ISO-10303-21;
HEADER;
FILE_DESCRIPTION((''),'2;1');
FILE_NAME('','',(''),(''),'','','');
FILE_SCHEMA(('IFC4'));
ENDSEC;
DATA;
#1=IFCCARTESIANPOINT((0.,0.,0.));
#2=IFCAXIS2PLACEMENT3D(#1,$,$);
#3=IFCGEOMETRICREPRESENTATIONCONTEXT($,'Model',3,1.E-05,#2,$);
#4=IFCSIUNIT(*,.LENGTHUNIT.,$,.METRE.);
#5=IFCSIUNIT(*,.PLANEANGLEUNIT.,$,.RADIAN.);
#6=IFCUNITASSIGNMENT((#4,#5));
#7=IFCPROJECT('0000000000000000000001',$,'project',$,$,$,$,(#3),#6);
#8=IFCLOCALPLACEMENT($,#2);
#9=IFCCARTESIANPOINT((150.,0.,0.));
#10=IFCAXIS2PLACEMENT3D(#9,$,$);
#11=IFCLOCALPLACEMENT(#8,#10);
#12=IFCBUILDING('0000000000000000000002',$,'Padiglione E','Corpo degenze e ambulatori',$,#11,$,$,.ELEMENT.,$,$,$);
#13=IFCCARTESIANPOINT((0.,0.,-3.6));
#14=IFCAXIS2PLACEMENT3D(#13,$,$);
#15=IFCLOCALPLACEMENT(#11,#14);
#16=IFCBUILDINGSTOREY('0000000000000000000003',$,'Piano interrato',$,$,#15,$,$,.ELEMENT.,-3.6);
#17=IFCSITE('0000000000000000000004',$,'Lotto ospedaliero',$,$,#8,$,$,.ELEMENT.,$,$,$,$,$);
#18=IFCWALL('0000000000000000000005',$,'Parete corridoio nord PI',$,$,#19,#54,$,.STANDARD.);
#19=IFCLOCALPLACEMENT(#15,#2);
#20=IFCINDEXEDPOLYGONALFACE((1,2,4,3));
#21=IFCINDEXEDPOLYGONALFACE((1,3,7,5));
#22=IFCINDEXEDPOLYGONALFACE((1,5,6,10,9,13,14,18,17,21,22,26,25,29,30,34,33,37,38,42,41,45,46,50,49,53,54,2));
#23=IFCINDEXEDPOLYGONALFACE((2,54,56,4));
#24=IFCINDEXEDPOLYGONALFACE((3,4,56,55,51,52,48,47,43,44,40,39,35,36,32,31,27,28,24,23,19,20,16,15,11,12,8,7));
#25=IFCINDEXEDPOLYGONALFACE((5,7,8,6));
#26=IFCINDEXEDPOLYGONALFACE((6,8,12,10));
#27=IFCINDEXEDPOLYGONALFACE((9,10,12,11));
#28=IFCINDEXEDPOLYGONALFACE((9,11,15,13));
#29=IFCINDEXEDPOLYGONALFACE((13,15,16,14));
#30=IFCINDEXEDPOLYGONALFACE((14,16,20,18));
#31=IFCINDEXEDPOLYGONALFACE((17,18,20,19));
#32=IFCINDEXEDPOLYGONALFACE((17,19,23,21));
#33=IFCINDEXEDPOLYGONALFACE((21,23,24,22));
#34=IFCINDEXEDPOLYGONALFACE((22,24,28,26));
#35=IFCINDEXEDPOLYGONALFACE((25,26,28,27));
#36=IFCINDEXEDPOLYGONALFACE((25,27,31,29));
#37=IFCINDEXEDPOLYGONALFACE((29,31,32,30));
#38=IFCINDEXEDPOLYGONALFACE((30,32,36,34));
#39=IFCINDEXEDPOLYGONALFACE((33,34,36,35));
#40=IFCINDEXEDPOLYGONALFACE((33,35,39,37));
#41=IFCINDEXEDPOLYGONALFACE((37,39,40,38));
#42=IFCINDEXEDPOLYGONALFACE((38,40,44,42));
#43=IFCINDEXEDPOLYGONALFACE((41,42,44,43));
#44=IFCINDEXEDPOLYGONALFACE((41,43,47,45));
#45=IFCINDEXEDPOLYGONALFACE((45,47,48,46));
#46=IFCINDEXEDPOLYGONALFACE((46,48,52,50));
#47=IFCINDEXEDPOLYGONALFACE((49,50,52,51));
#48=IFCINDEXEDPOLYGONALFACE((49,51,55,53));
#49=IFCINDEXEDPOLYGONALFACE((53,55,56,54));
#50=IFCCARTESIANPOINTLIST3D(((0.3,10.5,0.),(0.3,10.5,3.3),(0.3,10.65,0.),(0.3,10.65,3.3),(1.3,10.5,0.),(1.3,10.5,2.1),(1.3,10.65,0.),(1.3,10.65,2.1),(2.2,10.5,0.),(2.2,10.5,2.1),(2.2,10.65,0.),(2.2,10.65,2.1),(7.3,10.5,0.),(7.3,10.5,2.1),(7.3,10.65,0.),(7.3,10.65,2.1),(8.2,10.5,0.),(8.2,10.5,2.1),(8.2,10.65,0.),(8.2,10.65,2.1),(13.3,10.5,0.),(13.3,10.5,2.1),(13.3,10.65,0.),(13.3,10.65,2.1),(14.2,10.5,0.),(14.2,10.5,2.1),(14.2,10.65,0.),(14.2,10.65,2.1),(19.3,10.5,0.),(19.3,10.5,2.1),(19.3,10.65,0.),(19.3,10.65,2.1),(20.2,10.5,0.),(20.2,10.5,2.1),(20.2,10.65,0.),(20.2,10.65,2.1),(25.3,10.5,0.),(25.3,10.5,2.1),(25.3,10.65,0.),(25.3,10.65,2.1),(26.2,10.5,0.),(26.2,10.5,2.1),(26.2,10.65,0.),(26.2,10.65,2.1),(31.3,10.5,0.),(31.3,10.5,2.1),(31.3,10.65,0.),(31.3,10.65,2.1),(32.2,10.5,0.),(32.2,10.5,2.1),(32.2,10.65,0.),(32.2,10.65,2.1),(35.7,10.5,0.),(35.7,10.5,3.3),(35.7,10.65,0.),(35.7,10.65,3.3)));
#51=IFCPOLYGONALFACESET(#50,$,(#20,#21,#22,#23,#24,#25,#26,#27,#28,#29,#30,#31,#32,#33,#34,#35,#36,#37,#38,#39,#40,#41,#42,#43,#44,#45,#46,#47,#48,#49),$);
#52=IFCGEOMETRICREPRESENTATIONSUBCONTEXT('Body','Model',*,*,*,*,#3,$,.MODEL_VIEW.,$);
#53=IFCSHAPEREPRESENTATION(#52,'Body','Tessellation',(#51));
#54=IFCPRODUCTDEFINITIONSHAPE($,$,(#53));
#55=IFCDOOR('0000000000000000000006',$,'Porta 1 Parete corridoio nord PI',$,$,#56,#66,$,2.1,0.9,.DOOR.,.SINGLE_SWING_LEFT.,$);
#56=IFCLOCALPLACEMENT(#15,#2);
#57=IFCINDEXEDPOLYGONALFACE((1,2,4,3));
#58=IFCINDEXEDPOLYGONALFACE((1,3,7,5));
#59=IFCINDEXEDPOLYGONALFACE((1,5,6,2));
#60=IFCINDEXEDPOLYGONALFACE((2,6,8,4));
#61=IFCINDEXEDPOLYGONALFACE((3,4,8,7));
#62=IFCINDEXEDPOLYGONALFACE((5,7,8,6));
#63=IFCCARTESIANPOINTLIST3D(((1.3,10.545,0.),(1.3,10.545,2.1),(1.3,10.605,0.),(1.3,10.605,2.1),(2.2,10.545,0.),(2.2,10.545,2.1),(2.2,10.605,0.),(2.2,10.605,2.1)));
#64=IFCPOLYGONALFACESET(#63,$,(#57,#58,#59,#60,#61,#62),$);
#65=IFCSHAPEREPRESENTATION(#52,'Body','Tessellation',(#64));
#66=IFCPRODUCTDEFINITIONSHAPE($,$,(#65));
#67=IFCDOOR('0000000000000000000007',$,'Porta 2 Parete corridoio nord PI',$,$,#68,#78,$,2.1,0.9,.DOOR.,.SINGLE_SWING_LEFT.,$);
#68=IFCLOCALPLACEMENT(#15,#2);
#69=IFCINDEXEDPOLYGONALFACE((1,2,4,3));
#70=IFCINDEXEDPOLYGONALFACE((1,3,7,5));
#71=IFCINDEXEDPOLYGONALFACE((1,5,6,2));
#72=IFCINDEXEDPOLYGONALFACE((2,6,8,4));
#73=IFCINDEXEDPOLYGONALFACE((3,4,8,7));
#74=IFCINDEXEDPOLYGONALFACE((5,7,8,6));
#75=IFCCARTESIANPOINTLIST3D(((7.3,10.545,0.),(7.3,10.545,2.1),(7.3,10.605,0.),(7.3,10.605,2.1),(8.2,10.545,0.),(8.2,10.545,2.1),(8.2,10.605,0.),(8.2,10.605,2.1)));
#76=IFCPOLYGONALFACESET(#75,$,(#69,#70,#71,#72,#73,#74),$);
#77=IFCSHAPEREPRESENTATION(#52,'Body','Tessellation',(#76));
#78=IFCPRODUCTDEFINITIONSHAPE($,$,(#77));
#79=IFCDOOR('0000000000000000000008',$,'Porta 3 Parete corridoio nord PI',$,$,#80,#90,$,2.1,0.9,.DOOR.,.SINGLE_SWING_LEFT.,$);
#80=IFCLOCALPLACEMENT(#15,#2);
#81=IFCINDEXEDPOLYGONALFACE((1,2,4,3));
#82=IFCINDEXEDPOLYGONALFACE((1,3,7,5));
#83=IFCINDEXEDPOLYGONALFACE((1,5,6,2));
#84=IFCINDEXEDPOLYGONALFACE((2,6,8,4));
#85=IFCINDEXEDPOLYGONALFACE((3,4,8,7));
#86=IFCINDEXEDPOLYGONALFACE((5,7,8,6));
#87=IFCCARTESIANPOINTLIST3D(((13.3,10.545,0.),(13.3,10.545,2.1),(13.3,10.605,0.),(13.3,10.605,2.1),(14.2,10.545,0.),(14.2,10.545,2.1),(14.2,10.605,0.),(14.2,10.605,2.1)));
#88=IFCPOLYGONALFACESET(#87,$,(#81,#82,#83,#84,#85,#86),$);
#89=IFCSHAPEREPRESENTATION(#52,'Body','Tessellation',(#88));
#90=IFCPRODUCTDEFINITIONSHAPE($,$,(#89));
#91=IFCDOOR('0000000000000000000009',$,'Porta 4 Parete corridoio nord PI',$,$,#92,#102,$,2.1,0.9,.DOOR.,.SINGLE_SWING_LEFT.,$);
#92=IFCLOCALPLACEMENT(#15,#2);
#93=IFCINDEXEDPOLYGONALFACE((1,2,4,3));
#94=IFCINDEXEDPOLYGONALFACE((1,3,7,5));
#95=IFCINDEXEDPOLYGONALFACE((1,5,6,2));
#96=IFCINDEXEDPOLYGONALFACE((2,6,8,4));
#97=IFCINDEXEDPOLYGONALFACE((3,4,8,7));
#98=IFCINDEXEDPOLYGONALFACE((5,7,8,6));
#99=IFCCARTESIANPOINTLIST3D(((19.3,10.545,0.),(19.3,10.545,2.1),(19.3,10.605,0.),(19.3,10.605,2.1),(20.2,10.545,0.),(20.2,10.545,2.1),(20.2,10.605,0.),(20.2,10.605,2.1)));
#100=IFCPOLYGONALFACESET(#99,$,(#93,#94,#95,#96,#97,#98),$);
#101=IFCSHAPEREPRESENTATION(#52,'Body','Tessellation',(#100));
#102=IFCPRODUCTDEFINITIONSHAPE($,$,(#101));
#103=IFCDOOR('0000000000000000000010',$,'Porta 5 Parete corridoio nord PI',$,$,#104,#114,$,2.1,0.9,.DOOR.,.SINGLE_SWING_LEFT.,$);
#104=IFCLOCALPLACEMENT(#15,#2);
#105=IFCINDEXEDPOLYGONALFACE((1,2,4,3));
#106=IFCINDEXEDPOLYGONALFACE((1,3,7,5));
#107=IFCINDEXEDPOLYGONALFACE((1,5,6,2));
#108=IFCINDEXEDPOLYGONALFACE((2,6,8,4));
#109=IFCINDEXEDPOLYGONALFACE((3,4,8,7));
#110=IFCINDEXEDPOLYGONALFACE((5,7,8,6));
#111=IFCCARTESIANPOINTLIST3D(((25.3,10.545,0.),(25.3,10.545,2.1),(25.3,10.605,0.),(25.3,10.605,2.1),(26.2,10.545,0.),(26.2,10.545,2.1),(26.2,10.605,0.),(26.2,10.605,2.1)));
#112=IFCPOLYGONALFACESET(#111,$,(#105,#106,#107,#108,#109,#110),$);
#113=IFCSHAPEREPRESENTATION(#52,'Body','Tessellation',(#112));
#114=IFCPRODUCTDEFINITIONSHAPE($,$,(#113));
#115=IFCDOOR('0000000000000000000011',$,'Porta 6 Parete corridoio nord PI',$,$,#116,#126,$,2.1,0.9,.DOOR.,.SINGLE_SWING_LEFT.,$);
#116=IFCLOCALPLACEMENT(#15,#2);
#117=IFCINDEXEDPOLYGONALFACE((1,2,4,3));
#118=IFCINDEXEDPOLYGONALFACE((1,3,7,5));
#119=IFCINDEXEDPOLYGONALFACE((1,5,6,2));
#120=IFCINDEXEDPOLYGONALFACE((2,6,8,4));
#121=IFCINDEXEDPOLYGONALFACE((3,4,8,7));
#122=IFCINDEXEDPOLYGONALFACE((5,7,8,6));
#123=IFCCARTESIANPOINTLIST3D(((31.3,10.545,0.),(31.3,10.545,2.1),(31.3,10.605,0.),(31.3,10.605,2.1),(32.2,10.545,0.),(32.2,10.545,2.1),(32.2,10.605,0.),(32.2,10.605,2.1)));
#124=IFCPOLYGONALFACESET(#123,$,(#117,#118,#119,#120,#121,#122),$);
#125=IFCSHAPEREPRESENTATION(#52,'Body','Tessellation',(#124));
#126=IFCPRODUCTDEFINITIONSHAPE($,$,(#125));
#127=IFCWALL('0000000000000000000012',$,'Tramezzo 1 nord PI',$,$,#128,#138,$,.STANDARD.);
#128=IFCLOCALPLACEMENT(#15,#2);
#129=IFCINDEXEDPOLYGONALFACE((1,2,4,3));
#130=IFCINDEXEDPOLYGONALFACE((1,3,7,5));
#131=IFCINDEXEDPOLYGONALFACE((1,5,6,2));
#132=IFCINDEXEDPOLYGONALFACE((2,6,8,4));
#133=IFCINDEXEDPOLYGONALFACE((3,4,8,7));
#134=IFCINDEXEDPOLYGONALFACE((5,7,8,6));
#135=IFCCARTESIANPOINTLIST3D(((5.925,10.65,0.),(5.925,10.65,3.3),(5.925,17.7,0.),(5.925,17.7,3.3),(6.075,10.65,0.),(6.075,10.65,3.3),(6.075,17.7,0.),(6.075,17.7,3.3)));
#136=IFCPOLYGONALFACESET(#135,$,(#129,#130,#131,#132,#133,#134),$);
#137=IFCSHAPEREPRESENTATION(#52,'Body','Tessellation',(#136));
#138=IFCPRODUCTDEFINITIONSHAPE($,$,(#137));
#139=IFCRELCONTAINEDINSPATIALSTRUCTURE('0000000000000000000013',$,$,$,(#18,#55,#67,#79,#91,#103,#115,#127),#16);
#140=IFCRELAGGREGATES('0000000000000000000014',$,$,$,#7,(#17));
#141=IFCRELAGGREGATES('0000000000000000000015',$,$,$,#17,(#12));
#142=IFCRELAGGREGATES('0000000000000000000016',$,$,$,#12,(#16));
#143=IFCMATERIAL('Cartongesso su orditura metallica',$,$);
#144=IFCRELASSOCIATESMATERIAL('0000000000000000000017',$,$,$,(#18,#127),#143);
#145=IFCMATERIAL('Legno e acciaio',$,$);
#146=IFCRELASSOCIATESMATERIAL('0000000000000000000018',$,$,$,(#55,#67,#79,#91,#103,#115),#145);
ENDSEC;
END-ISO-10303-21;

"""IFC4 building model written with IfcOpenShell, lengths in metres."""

from ifc_helpers import new_model, si_unit, frame, frame_2d, origin, place, context, subcontext, project, spatial, rectangle, extrude, material, element, fill, save


model = new_model("IFC4")

# Units and contexts
model_context = context("Model", 3, precision=1e-05, world=origin())
body_context = subcontext(model_context, "Body", "Model", "MODEL_VIEW")
ifc_project = project(units=[si_unit("LENGTHUNIT", "METRE"), si_unit("PLANEANGLEUNIT", "RADIAN")], contexts=[model_context])

# Site, building, storey
site_placement = place(None, origin())
site = spatial("IfcSite", under=ifc_project, at=site_placement, Name="Lotto ospedaliero", CompositionType="ELEMENT")
building_placement = place(site_placement, frame((150.0, 0.0, 0.0)))
building = spatial("IfcBuilding", under=site, at=building_placement, Name="Padiglione E", Description="Corpo degenze e ambulatori", CompositionType="ELEMENT")
storey_placement = place(building_placement, frame((0.0, 0.0, -3.6)))
storey = spatial("IfcBuildingStorey", under=building, at=storey_placement, Name="Piano interrato", CompositionType="ELEMENT", Elevation=-3.6)

# Wall, openings, doors
ifc_material_1 = material(Name="Cartongesso su orditura metallica")
ifc_material_2 = material(Name="Legno e acciaio")
wall_1_placement = place(storey_placement, frame((0.3, 10.5, 0.0)))
wall_1 = element("IfcWall", 1, at=wall_1_placement, inside=storey, material=ifc_material_1, Name="Parete corridoio nord PI", PredefinedType="STANDARD", context=body_context, shape_type="SweptSolid", body=[
    extrude(rectangle(XDim=35.4, YDim=0.15, at=frame_2d((17.7, 0.075))), origin(), (0.0, 0.0, 1.0), 3.3),
])
opening_1_placement = place(wall_1_placement, frame((1.0, -0.1, 0.0)))
opening_1 = element("IfcOpeningElement", 2, at=opening_1_placement, cuts=wall_1, PredefinedType="OPENING", context=body_context, shape_type="SweptSolid", body=[
    extrude(rectangle(XDim=0.9, YDim=0.35, at=frame_2d((0.45, 0.175))), origin(), (0.0, 0.0, 1.0), 2.1),
])
opening_2_placement = place(wall_1_placement, frame((7.0, -0.1, 0.0)))
opening_2 = element("IfcOpeningElement", 3, at=opening_2_placement, cuts=wall_1, PredefinedType="OPENING", context=body_context, shape_type="SweptSolid", body=[
    extrude(rectangle(XDim=0.9, YDim=0.35, at=frame_2d((0.45, 0.175))), origin(), (0.0, 0.0, 1.0), 2.1),
])
opening_3_placement = place(wall_1_placement, frame((13.0, -0.1, 0.0)))
opening_3 = element("IfcOpeningElement", 4, at=opening_3_placement, cuts=wall_1, PredefinedType="OPENING", context=body_context, shape_type="SweptSolid", body=[
    extrude(rectangle(XDim=0.9, YDim=0.35, at=frame_2d((0.45, 0.175))), origin(), (0.0, 0.0, 1.0), 2.1),
])
opening_4_placement = place(wall_1_placement, frame((19.0, -0.1, 0.0)))
opening_4 = element("IfcOpeningElement", 5, at=opening_4_placement, cuts=wall_1, PredefinedType="OPENING", context=body_context, shape_type="SweptSolid", body=[
    extrude(rectangle(XDim=0.9, YDim=0.35, at=frame_2d((0.45, 0.175))), origin(), (0.0, 0.0, 1.0), 2.1),
])
opening_5_placement = place(wall_1_placement, frame((25.0, -0.1, 0.0)))
opening_5 = element("IfcOpeningElement", 6, at=opening_5_placement, cuts=wall_1, PredefinedType="OPENING", context=body_context, shape_type="SweptSolid", body=[
    extrude(rectangle(XDim=0.9, YDim=0.35, at=frame_2d((0.45, 0.175))), origin(), (0.0, 0.0, 1.0), 2.1),
])
opening_6_placement = place(wall_1_placement, frame((31.0, -0.1, 0.0)))
opening_6 = element("IfcOpeningElement", 7, at=opening_6_placement, cuts=wall_1, PredefinedType="OPENING", context=body_context, shape_type="SweptSolid", body=[
    extrude(rectangle(XDim=0.9, YDim=0.35, at=frame_2d((0.45, 0.175))), origin(), (0.0, 0.0, 1.0), 2.1),
])
door_1_placement = place(wall_1_placement, frame((1.0, 0.045, 0.0)))
door_1 = element("IfcDoor", 8, at=door_1_placement, inside=storey, material=ifc_material_2, Name="Porta 1 Parete corridoio nord PI", OperationType="SINGLE_SWING_LEFT", OverallHeight=2.1, OverallWidth=0.9, PredefinedType="DOOR", context=body_context, shape_type="SweptSolid", body=[
    extrude(rectangle(XDim=0.9, YDim=0.06, at=frame_2d((0.45, 0.03))), origin(), (0.0, 0.0, 1.0), 2.1),
])
fill(opening_1, door_1)
door_2_placement = place(wall_1_placement, frame((7.0, 0.045, 0.0)))
door_2 = element("IfcDoor", 9, at=door_2_placement, inside=storey, material=ifc_material_2, Name="Porta 2 Parete corridoio nord PI", OperationType="SINGLE_SWING_LEFT", OverallHeight=2.1, OverallWidth=0.9, PredefinedType="DOOR", context=body_context, shape_type="SweptSolid", body=[
    extrude(rectangle(XDim=0.9, YDim=0.06, at=frame_2d((0.45, 0.03))), origin(), (0.0, 0.0, 1.0), 2.1),
])
fill(opening_2, door_2)
door_3_placement = place(wall_1_placement, frame((13.0, 0.045, 0.0)))
door_3 = element("IfcDoor", 10, at=door_3_placement, inside=storey, material=ifc_material_2, Name="Porta 3 Parete corridoio nord PI", OperationType="SINGLE_SWING_LEFT", OverallHeight=2.1, OverallWidth=0.9, PredefinedType="DOOR", context=body_context, shape_type="SweptSolid", body=[
    extrude(rectangle(XDim=0.9, YDim=0.06, at=frame_2d((0.45, 0.03))), origin(), (0.0, 0.0, 1.0), 2.1),
])
fill(opening_3, door_3)
door_4_placement = place(wall_1_placement, frame((19.0, 0.045, 0.0)))
door_4 = element("IfcDoor", 11, at=door_4_placement, inside=storey, material=ifc_material_2, Name="Porta 4 Parete corridoio nord PI", OperationType="SINGLE_SWING_LEFT", OverallHeight=2.1, OverallWidth=0.9, PredefinedType="DOOR", context=body_context, shape_type="SweptSolid", body=[
    extrude(rectangle(XDim=0.9, YDim=0.06, at=frame_2d((0.45, 0.03))), origin(), (0.0, 0.0, 1.0), 2.1),
])
fill(opening_4, door_4)
door_5_placement = place(wall_1_placement, frame((25.0, 0.045, 0.0)))
door_5 = element("IfcDoor", 12, at=door_5_placement, inside=storey, material=ifc_material_2, Name="Porta 5 Parete corridoio nord PI", OperationType="SINGLE_SWING_LEFT", OverallHeight=2.1, OverallWidth=0.9, PredefinedType="DOOR", context=body_context, shape_type="SweptSolid", body=[
    extrude(rectangle(XDim=0.9, YDim=0.06, at=frame_2d((0.45, 0.03))), origin(), (0.0, 0.0, 1.0), 2.1),
])
fill(opening_5, door_5)
door_6_placement = place(wall_1_placement, frame((31.0, 0.045, 0.0)))
door_6 = element("IfcDoor", 13, at=door_6_placement, inside=storey, material=ifc_material_2, Name="Porta 6 Parete corridoio nord PI", OperationType="SINGLE_SWING_LEFT", OverallHeight=2.1, OverallWidth=0.9, PredefinedType="DOOR", context=body_context, shape_type="SweptSolid", body=[
    extrude(rectangle(XDim=0.9, YDim=0.06, at=frame_2d((0.45, 0.03))), origin(), (0.0, 0.0, 1.0), 2.1),
])
fill(opening_6, door_6)

# Wall
wall_2_placement = place(storey_placement, frame((5.925, 10.65, 0.0)))
element("IfcWall", 14, at=wall_2_placement, inside=storey, material=ifc_material_1, Name="Tramezzo 1 nord PI", PredefinedType="STANDARD", context=body_context, shape_type="SweptSolid", body=[
    extrude(rectangle(XDim=0.15, YDim=7.05, at=frame_2d((0.075, 3.525))), origin(), (0.0, 0.0, 1.0), 3.3),
])

save(model, "model.ifc")
